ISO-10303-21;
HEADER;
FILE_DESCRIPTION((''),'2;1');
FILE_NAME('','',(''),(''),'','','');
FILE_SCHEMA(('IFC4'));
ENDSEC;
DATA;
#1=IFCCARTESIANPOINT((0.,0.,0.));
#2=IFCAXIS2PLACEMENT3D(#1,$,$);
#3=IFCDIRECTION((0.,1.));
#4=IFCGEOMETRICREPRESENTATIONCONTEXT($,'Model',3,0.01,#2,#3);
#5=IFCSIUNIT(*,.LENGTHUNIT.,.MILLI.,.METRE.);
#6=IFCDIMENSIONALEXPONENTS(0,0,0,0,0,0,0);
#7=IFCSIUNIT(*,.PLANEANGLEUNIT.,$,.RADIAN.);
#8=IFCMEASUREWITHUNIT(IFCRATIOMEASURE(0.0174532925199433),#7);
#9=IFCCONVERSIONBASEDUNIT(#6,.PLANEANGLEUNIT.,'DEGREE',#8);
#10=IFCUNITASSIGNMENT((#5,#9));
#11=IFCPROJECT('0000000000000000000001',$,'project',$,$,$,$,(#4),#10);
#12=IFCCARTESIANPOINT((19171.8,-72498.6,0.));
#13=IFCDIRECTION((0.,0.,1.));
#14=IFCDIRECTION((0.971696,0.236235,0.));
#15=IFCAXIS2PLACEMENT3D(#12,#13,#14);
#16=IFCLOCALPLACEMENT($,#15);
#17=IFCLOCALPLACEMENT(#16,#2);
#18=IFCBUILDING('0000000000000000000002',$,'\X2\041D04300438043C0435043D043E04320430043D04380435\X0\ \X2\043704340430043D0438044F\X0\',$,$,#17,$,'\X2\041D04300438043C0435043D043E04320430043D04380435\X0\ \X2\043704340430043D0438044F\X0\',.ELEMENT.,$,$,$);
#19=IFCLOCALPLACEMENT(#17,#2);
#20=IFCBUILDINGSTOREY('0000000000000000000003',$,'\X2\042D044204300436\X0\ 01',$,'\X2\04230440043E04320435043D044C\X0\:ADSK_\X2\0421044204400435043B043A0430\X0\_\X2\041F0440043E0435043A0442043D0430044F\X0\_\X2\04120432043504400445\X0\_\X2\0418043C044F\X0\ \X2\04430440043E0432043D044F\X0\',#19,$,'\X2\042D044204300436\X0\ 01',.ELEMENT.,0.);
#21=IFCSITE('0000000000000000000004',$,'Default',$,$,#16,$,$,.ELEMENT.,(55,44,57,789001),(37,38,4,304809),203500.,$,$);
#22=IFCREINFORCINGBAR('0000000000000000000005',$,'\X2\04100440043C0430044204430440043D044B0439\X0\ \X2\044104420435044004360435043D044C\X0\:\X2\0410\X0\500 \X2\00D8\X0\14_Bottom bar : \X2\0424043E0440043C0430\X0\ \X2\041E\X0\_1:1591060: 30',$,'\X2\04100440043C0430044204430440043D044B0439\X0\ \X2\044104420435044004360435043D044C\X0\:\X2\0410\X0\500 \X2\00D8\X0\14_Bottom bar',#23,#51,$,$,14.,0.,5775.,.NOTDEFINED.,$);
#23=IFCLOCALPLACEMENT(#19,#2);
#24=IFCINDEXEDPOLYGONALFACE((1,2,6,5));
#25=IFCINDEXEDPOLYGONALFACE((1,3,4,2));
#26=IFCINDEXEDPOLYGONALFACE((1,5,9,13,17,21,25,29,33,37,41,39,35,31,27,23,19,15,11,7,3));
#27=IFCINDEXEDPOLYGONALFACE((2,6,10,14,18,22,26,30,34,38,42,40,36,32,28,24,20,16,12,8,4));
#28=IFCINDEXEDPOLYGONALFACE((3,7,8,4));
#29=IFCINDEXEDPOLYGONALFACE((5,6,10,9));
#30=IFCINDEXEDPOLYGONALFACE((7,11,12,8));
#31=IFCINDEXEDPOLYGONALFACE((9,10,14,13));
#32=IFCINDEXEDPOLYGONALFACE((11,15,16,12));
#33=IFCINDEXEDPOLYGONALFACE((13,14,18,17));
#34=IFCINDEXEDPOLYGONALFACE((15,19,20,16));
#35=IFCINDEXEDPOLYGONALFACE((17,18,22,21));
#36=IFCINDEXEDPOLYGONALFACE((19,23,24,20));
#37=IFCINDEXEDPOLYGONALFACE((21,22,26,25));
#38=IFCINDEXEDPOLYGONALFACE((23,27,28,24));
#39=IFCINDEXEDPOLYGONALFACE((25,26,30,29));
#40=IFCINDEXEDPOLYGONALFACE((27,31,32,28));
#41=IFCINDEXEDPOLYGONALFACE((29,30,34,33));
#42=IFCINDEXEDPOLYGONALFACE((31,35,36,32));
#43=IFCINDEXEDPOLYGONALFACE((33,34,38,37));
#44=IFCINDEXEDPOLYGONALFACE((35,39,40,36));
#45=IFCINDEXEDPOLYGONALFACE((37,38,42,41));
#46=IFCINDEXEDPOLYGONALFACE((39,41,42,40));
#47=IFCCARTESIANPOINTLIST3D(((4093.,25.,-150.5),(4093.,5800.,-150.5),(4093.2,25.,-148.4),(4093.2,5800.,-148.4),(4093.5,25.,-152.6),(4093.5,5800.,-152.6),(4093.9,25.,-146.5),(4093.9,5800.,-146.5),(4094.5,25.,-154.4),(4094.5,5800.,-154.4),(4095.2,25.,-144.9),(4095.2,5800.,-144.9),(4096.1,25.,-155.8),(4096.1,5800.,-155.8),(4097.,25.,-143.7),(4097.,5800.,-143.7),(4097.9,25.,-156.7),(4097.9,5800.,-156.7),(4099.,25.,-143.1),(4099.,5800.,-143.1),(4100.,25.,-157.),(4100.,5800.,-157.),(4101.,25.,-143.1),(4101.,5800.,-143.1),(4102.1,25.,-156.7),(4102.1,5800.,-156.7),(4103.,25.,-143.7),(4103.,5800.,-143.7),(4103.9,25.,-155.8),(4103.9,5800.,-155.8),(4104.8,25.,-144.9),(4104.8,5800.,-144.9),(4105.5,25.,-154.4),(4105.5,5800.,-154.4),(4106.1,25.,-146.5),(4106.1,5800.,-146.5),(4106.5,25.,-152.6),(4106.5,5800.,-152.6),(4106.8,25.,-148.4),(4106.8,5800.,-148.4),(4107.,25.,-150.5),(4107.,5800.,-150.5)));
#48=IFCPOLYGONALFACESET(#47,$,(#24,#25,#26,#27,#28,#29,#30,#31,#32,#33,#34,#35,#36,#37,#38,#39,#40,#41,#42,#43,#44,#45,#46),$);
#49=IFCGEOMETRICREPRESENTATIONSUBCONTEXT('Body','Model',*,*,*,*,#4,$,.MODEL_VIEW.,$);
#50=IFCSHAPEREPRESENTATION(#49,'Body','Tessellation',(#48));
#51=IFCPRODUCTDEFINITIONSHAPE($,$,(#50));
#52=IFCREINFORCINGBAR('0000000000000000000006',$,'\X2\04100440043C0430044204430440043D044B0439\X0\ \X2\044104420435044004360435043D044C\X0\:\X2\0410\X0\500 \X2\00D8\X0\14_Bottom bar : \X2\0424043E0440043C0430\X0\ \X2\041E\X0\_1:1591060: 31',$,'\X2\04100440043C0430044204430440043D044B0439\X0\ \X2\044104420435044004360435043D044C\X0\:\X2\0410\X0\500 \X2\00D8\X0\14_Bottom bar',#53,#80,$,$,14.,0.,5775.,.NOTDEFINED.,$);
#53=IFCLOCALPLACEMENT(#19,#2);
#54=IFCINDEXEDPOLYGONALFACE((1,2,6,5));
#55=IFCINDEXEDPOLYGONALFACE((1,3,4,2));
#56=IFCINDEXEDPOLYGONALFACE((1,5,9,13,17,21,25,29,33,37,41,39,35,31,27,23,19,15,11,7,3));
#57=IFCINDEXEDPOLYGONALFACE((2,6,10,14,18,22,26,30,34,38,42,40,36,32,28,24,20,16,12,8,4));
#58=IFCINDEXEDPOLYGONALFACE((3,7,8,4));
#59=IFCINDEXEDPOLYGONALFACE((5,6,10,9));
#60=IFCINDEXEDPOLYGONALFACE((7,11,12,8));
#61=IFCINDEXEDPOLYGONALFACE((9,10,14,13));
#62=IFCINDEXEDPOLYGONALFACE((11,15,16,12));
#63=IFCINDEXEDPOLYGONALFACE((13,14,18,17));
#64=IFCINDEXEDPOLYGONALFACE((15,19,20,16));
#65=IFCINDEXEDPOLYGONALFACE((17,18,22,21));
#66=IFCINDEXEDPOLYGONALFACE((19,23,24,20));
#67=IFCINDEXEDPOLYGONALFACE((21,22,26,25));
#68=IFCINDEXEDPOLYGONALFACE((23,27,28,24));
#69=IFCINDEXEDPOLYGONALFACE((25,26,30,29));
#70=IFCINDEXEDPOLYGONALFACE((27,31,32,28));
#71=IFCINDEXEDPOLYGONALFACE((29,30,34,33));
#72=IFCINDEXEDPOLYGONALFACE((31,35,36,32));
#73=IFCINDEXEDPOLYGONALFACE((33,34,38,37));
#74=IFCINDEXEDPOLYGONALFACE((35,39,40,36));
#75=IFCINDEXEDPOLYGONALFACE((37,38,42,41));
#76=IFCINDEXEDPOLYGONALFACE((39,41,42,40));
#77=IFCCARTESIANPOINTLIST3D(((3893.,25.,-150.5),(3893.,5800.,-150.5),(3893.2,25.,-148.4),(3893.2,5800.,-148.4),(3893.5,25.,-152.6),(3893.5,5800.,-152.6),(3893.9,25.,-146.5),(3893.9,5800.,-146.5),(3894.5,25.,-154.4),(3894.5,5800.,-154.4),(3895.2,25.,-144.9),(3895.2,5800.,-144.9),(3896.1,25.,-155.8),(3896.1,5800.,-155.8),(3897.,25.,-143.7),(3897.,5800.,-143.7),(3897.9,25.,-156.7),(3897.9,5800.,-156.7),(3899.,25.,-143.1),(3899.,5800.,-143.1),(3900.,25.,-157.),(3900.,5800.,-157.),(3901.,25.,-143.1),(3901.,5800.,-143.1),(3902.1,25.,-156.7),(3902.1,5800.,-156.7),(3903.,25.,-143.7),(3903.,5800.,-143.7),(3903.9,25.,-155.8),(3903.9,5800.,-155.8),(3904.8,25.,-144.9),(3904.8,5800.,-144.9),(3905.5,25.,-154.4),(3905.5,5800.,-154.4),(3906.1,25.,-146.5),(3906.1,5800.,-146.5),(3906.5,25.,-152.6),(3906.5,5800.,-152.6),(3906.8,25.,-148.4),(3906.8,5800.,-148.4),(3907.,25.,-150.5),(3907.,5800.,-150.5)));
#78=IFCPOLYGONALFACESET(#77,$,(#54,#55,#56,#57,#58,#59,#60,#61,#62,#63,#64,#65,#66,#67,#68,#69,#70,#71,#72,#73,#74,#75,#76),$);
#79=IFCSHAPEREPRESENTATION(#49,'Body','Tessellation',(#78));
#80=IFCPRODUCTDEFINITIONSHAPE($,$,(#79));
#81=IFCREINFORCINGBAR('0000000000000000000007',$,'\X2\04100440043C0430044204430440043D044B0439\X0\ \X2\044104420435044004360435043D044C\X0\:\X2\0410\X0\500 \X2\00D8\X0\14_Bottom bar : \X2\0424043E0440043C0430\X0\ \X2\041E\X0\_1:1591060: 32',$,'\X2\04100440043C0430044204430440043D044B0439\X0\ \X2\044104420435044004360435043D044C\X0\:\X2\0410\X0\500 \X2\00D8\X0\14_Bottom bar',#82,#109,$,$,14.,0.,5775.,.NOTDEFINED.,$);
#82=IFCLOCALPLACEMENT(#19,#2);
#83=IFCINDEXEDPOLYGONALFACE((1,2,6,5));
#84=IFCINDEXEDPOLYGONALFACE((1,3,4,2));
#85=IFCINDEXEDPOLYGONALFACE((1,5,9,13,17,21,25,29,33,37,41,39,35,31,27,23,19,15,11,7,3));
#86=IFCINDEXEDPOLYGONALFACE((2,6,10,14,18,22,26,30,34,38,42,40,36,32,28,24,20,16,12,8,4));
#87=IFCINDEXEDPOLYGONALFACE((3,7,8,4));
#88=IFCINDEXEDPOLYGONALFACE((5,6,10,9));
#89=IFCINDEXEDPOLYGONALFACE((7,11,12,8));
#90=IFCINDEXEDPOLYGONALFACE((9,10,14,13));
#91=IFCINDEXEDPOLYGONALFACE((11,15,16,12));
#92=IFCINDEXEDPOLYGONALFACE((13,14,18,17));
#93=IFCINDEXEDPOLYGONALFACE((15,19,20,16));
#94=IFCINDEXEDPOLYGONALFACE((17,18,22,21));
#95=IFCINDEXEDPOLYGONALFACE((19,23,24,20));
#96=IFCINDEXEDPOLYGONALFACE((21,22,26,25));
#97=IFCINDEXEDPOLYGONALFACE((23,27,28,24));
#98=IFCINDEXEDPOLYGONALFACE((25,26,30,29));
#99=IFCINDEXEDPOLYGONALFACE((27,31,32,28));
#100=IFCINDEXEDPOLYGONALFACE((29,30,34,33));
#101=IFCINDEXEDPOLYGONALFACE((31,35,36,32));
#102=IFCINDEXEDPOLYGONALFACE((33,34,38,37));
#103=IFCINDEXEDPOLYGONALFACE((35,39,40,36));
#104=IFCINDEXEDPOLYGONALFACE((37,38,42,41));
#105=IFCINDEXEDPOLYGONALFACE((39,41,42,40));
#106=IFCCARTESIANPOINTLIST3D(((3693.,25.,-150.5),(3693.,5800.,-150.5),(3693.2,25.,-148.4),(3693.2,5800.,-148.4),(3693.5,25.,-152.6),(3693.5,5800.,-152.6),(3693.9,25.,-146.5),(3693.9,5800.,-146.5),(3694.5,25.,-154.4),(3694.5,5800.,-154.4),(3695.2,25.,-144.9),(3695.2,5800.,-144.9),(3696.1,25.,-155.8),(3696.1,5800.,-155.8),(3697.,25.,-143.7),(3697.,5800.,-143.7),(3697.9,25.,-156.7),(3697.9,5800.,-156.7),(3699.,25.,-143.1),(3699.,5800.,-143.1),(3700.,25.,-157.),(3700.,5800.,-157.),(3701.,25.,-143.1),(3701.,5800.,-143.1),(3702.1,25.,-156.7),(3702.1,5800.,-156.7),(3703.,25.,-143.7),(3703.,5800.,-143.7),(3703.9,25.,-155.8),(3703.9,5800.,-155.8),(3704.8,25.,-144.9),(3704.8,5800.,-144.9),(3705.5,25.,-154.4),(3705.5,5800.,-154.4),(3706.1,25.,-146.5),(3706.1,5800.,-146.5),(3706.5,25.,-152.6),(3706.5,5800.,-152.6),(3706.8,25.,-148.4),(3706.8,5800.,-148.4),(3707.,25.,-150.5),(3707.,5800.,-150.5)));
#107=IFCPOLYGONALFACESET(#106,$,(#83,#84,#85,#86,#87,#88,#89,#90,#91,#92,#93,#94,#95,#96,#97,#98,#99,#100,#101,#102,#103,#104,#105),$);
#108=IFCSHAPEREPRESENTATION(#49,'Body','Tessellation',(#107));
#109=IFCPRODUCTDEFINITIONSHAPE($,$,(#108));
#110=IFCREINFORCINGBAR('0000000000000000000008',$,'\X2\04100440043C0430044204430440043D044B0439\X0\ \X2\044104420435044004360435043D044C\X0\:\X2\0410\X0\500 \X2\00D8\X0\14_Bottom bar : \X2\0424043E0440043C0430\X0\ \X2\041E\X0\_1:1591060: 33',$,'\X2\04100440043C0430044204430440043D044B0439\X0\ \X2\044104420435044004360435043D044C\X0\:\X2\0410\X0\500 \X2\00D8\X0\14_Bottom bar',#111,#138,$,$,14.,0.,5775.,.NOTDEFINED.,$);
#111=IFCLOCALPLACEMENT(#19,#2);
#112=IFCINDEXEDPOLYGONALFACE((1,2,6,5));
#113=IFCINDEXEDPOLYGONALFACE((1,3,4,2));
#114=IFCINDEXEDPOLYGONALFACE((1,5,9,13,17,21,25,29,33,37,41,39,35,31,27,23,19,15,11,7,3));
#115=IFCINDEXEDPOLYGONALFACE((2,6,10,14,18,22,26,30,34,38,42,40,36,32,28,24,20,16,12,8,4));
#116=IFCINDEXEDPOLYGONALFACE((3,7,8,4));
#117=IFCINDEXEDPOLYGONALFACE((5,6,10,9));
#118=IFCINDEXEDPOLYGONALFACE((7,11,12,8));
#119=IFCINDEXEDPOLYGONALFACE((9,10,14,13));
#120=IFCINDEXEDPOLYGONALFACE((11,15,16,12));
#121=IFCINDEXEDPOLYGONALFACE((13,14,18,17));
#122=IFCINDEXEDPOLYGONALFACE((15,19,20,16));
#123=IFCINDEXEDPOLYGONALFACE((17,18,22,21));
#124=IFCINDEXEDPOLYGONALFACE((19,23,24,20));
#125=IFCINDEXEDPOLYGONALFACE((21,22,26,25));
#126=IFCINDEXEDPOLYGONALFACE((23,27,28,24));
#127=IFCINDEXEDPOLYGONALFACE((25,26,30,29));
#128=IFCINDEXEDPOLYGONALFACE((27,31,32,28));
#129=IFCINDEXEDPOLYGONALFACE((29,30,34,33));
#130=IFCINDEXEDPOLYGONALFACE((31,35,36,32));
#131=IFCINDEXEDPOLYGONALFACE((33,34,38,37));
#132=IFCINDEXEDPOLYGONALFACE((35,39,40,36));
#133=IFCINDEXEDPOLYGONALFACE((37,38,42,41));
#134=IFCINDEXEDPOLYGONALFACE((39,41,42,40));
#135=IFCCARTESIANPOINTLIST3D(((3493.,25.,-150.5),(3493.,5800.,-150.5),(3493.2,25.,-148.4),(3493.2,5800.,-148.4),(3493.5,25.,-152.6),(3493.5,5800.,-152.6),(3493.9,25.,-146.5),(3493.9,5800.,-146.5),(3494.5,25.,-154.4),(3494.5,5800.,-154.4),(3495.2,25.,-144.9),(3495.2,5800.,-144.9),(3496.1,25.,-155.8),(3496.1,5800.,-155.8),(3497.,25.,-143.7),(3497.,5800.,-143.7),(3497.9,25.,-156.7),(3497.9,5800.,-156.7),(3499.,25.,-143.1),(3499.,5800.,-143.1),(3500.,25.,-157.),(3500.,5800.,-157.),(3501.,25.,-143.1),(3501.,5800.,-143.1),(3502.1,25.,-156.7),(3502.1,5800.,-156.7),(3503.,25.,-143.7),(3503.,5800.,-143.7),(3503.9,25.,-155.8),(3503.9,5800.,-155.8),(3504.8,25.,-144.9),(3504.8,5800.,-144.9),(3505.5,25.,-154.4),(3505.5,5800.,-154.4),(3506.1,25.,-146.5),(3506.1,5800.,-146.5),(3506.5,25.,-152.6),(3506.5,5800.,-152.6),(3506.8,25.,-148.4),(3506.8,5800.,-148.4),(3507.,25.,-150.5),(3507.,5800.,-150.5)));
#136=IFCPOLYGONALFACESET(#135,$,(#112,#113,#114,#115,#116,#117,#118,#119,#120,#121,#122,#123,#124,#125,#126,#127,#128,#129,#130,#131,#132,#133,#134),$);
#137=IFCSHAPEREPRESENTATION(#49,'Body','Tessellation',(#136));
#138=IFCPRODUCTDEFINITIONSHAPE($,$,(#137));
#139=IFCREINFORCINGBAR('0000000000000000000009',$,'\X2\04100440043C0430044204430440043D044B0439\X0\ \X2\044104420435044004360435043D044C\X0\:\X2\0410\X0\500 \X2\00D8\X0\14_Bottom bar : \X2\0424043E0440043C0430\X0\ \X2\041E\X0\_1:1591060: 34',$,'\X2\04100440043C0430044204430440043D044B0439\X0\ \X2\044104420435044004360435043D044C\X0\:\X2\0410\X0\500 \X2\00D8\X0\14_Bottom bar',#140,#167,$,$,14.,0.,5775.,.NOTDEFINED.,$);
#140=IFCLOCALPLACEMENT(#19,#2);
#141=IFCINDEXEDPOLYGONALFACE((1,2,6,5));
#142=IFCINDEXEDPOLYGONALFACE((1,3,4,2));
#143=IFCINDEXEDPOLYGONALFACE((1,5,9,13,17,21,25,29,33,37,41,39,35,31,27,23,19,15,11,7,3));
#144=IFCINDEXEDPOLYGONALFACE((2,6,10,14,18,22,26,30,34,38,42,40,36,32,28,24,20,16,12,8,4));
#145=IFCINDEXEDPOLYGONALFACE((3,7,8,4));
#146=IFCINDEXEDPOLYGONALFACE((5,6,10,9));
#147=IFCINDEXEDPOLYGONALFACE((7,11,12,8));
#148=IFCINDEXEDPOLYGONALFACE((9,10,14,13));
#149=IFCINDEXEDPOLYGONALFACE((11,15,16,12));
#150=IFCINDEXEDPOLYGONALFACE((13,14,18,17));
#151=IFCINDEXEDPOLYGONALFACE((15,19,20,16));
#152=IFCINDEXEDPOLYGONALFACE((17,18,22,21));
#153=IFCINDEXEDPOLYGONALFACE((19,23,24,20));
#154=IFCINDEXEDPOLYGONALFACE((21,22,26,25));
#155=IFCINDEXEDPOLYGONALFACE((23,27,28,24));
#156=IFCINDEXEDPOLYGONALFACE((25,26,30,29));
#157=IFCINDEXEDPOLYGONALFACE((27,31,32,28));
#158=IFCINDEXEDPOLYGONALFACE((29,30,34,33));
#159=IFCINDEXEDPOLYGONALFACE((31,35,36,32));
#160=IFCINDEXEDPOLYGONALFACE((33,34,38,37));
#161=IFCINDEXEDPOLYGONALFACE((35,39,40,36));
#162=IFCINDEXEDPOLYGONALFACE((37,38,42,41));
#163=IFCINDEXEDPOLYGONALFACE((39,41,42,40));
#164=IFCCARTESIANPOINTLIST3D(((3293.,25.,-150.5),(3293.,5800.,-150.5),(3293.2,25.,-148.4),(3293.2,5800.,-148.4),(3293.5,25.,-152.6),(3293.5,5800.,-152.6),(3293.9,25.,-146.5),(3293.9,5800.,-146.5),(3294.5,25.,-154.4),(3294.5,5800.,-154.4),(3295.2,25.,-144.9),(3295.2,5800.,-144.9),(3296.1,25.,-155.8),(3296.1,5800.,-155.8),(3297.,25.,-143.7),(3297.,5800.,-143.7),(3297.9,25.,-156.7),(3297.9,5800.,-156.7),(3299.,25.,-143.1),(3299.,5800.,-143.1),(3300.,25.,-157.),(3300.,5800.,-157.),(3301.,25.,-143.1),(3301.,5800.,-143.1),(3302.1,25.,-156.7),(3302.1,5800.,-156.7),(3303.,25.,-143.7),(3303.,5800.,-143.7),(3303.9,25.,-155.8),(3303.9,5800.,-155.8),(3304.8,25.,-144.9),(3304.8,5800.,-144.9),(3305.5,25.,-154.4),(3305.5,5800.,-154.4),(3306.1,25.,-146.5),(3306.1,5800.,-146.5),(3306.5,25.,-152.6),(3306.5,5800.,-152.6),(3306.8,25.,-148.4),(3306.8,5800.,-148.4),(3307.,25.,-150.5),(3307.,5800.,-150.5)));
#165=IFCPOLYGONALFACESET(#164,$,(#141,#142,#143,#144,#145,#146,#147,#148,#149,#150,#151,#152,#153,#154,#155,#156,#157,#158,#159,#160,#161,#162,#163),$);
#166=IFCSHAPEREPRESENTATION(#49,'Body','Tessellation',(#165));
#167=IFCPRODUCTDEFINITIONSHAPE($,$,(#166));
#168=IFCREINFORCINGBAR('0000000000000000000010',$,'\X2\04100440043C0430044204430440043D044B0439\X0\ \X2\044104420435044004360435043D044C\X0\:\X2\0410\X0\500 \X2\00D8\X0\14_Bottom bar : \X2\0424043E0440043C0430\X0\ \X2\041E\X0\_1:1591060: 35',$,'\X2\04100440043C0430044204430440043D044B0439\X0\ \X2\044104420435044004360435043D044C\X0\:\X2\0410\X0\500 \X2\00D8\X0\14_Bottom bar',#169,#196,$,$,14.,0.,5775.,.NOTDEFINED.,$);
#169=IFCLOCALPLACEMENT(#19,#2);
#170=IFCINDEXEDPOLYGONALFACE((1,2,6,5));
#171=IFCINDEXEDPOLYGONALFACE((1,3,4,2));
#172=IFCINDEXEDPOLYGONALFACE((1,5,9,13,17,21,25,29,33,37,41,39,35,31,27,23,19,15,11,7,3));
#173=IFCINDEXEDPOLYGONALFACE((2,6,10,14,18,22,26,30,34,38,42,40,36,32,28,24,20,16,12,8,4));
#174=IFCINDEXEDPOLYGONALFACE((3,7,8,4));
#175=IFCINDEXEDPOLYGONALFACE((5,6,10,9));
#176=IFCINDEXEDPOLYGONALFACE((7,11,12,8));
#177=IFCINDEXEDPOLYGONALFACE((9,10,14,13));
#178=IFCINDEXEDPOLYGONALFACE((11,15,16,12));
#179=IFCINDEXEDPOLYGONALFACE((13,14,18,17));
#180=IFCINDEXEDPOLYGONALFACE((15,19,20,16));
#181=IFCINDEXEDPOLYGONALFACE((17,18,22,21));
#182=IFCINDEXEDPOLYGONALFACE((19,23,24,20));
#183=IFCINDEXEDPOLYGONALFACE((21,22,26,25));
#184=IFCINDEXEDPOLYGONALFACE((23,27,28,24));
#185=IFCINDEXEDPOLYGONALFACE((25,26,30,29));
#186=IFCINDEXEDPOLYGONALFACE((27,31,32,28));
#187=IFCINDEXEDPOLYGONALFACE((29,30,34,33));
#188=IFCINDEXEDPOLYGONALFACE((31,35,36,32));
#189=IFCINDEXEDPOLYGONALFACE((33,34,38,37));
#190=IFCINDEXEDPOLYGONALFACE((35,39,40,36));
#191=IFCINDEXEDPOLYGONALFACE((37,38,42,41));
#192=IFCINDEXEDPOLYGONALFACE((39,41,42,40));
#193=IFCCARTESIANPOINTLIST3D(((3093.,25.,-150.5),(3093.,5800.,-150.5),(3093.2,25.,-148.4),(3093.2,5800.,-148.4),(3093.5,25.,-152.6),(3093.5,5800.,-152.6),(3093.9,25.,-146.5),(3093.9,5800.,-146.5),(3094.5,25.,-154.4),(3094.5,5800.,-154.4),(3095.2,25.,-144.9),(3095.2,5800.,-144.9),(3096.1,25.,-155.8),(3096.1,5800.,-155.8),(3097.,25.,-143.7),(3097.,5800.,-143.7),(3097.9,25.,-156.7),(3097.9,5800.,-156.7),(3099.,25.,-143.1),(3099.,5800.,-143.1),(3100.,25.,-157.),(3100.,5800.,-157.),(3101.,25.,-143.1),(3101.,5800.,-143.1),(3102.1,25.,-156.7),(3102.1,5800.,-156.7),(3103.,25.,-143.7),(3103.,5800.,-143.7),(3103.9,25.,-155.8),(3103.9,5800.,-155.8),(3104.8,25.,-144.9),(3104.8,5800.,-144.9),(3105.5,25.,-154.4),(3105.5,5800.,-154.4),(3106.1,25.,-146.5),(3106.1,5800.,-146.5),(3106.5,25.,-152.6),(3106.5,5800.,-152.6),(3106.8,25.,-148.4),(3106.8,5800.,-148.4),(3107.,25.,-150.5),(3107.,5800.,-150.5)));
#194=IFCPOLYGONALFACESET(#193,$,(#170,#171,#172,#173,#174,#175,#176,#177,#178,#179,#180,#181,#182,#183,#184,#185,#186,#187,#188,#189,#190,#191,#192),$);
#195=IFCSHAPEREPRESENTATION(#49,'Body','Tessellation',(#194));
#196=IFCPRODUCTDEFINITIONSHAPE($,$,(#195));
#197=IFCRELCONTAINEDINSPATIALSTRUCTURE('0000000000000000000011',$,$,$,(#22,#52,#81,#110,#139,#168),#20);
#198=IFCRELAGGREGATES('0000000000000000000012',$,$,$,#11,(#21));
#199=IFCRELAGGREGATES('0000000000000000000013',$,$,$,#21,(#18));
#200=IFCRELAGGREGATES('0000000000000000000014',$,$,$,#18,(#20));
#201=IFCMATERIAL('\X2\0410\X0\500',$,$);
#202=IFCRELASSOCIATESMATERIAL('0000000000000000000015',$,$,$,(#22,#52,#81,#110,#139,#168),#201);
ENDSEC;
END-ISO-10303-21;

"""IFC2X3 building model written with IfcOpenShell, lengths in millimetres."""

from ifc_helpers import new_model, entity, si_unit, converted_unit, direction, frame, origin, place, context, subcontext, project, spatial, material, element, save


model = new_model("IFC2X3")

# Units and contexts
model_context = context("Model", 3, precision=0.01, world=origin(), true_north=direction((0.0, 1.0)))
body_context = subcontext(model_context, "Body", "Model", "MODEL_VIEW")
ifc_project = project(units=[si_unit("LENGTHUNIT", "METRE", prefix="MILLI"), converted_unit("PLANEANGLEUNIT", "DEGREE", entity("IfcRatioMeasure", 0.0174532925199433), si_unit("PLANEANGLEUNIT", "RADIAN"), dimensions=[0, 0, 0, 0, 0, 0, 0])], contexts=[model_context])

# Site, building, storey
site_placement = place(None, frame((19171.8, -72498.6, 0.0), z_axis=(0.0, 0.0, 1.0), x_axis=(0.971696, 0.236235, 0.0)))
site = spatial("IfcSite", under=ifc_project, at=site_placement, Name="Default", CompositionType="ELEMENT", RefLatitude=(55, 44, 57, 789001), RefLongitude=(37, 38, 4, 304809), RefElevation=203500.0)
building_placement = place(site_placement, origin())
building = spatial("IfcBuilding", under=site, at=building_placement, Name="Наименование здания", LongName="Наименование здания", CompositionType="ELEMENT")
storey_placement = place(building_placement, origin())
storey = spatial("IfcBuildingStorey", under=building, at=storey_placement, Name="Этаж 01", ObjectType="Уровень:ADSK_Стрелка_Проектная_Вверх_Имя уровня", LongName="Этаж 01", CompositionType="ELEMENT", Elevation=0.0)

# Reinforcing bars
ifc_material = material(Name="А500")
placement = place(storey_placement, origin())
element("IfcReinforcingBar", 1, at=placement, inside=storey, material=ifc_material, Name="Арматурный стержень:А500 Ø14_Bottom bar : Форма О_1:1591060: 30", ObjectType="Арматурный стержень:А500 Ø14_Bottom bar", BarLength=5775.0, BarRole="NOTDEFINED", CrossSectionArea=0.0, NominalDiameter=14.0, context=body_context, shape_type="AdvancedSweptSolid", body=[
    entity("IfcSweptDiskSolid", entity("IfcCompositeCurve", [entity("IfcCompositeCurveSegment", "CONTINUOUS", True, entity("IfcPolyline", [entity("IfcCartesianPoint", [4100.0, 5800.0, -150.0]), entity("IfcCartesianPoint", [4100.0, 25.0, -150.0])]))], False), 7.0, None, 0.0, 1.0),
])
element("IfcReinforcingBar", 2, at=placement, inside=storey, material=ifc_material, Name="Арматурный стержень:А500 Ø14_Bottom bar : Форма О_1:1591060: 31", ObjectType="Арматурный стержень:А500 Ø14_Bottom bar", BarLength=5775.0, BarRole="NOTDEFINED", CrossSectionArea=0.0, NominalDiameter=14.0, context=body_context, shape_type="AdvancedSweptSolid", body=[
    entity("IfcSweptDiskSolid", entity("IfcCompositeCurve", [entity("IfcCompositeCurveSegment", "CONTINUOUS", True, entity("IfcPolyline", [entity("IfcCartesianPoint", [3900.0, 5800.0, -150.0]), entity("IfcCartesianPoint", [3900.0, 25.0, -150.0])]))], False), 7.0, None, 0.0, 1.0),
])
element("IfcReinforcingBar", 3, at=placement, inside=storey, material=ifc_material, Name="Арматурный стержень:А500 Ø14_Bottom bar : Форма О_1:1591060: 32", ObjectType="Арматурный стержень:А500 Ø14_Bottom bar", BarLength=5775.0, BarRole="NOTDEFINED", CrossSectionArea=0.0, NominalDiameter=14.0, context=body_context, shape_type="AdvancedSweptSolid", body=[
    entity("IfcSweptDiskSolid", entity("IfcCompositeCurve", [entity("IfcCompositeCurveSegment", "CONTINUOUS", True, entity("IfcPolyline", [entity("IfcCartesianPoint", [3700.0, 5800.0, -150.0]), entity("IfcCartesianPoint", [3700.0, 25.0, -150.0])]))], False), 7.0, None, 0.0, 1.0),
])
element("IfcReinforcingBar", 4, at=placement, inside=storey, material=ifc_material, Name="Арматурный стержень:А500 Ø14_Bottom bar : Форма О_1:1591060: 33", ObjectType="Арматурный стержень:А500 Ø14_Bottom bar", BarLength=5775.0, BarRole="NOTDEFINED", CrossSectionArea=0.0, NominalDiameter=14.0, context=body_context, shape_type="AdvancedSweptSolid", body=[
    entity("IfcSweptDiskSolid", entity("IfcCompositeCurve", [entity("IfcCompositeCurveSegment", "CONTINUOUS", True, entity("IfcPolyline", [entity("IfcCartesianPoint", [3500.0, 5800.0, -150.0]), entity("IfcCartesianPoint", [3500.0, 25.0, -150.0])]))], False), 7.0, None, 0.0, 1.0),
])
element("IfcReinforcingBar", 5, at=placement, inside=storey, material=ifc_material, Name="Арматурный стержень:А500 Ø14_Bottom bar : Форма О_1:1591060: 34", ObjectType="Арматурный стержень:А500 Ø14_Bottom bar", BarLength=5775.0, BarRole="NOTDEFINED", CrossSectionArea=0.0, NominalDiameter=14.0, context=body_context, shape_type="AdvancedSweptSolid", body=[
    entity("IfcSweptDiskSolid", entity("IfcCompositeCurve", [entity("IfcCompositeCurveSegment", "CONTINUOUS", True, entity("IfcPolyline", [entity("IfcCartesianPoint", [3300.0, 5800.0, -150.0]), entity("IfcCartesianPoint", [3300.0, 25.0, -150.0])]))], False), 7.0, None, 0.0, 1.0),
])
element("IfcReinforcingBar", 6, at=placement, inside=storey, material=ifc_material, Name="Арматурный стержень:А500 Ø14_Bottom bar : Форма О_1:1591060: 35", ObjectType="Арматурный стержень:А500 Ø14_Bottom bar", BarLength=5775.0, BarRole="NOTDEFINED", CrossSectionArea=0.0, NominalDiameter=14.0, context=body_context, shape_type="AdvancedSweptSolid", body=[
    entity("IfcSweptDiskSolid", entity("IfcCompositeCurve", [entity("IfcCompositeCurveSegment", "CONTINUOUS", True, entity("IfcPolyline", [entity("IfcCartesianPoint", [3100.0, 5800.0, -150.0]), entity("IfcCartesianPoint", [3100.0, 25.0, -150.0])]))], False), 7.0, None, 0.0, 1.0),
])

save(model, "model.ifc")
